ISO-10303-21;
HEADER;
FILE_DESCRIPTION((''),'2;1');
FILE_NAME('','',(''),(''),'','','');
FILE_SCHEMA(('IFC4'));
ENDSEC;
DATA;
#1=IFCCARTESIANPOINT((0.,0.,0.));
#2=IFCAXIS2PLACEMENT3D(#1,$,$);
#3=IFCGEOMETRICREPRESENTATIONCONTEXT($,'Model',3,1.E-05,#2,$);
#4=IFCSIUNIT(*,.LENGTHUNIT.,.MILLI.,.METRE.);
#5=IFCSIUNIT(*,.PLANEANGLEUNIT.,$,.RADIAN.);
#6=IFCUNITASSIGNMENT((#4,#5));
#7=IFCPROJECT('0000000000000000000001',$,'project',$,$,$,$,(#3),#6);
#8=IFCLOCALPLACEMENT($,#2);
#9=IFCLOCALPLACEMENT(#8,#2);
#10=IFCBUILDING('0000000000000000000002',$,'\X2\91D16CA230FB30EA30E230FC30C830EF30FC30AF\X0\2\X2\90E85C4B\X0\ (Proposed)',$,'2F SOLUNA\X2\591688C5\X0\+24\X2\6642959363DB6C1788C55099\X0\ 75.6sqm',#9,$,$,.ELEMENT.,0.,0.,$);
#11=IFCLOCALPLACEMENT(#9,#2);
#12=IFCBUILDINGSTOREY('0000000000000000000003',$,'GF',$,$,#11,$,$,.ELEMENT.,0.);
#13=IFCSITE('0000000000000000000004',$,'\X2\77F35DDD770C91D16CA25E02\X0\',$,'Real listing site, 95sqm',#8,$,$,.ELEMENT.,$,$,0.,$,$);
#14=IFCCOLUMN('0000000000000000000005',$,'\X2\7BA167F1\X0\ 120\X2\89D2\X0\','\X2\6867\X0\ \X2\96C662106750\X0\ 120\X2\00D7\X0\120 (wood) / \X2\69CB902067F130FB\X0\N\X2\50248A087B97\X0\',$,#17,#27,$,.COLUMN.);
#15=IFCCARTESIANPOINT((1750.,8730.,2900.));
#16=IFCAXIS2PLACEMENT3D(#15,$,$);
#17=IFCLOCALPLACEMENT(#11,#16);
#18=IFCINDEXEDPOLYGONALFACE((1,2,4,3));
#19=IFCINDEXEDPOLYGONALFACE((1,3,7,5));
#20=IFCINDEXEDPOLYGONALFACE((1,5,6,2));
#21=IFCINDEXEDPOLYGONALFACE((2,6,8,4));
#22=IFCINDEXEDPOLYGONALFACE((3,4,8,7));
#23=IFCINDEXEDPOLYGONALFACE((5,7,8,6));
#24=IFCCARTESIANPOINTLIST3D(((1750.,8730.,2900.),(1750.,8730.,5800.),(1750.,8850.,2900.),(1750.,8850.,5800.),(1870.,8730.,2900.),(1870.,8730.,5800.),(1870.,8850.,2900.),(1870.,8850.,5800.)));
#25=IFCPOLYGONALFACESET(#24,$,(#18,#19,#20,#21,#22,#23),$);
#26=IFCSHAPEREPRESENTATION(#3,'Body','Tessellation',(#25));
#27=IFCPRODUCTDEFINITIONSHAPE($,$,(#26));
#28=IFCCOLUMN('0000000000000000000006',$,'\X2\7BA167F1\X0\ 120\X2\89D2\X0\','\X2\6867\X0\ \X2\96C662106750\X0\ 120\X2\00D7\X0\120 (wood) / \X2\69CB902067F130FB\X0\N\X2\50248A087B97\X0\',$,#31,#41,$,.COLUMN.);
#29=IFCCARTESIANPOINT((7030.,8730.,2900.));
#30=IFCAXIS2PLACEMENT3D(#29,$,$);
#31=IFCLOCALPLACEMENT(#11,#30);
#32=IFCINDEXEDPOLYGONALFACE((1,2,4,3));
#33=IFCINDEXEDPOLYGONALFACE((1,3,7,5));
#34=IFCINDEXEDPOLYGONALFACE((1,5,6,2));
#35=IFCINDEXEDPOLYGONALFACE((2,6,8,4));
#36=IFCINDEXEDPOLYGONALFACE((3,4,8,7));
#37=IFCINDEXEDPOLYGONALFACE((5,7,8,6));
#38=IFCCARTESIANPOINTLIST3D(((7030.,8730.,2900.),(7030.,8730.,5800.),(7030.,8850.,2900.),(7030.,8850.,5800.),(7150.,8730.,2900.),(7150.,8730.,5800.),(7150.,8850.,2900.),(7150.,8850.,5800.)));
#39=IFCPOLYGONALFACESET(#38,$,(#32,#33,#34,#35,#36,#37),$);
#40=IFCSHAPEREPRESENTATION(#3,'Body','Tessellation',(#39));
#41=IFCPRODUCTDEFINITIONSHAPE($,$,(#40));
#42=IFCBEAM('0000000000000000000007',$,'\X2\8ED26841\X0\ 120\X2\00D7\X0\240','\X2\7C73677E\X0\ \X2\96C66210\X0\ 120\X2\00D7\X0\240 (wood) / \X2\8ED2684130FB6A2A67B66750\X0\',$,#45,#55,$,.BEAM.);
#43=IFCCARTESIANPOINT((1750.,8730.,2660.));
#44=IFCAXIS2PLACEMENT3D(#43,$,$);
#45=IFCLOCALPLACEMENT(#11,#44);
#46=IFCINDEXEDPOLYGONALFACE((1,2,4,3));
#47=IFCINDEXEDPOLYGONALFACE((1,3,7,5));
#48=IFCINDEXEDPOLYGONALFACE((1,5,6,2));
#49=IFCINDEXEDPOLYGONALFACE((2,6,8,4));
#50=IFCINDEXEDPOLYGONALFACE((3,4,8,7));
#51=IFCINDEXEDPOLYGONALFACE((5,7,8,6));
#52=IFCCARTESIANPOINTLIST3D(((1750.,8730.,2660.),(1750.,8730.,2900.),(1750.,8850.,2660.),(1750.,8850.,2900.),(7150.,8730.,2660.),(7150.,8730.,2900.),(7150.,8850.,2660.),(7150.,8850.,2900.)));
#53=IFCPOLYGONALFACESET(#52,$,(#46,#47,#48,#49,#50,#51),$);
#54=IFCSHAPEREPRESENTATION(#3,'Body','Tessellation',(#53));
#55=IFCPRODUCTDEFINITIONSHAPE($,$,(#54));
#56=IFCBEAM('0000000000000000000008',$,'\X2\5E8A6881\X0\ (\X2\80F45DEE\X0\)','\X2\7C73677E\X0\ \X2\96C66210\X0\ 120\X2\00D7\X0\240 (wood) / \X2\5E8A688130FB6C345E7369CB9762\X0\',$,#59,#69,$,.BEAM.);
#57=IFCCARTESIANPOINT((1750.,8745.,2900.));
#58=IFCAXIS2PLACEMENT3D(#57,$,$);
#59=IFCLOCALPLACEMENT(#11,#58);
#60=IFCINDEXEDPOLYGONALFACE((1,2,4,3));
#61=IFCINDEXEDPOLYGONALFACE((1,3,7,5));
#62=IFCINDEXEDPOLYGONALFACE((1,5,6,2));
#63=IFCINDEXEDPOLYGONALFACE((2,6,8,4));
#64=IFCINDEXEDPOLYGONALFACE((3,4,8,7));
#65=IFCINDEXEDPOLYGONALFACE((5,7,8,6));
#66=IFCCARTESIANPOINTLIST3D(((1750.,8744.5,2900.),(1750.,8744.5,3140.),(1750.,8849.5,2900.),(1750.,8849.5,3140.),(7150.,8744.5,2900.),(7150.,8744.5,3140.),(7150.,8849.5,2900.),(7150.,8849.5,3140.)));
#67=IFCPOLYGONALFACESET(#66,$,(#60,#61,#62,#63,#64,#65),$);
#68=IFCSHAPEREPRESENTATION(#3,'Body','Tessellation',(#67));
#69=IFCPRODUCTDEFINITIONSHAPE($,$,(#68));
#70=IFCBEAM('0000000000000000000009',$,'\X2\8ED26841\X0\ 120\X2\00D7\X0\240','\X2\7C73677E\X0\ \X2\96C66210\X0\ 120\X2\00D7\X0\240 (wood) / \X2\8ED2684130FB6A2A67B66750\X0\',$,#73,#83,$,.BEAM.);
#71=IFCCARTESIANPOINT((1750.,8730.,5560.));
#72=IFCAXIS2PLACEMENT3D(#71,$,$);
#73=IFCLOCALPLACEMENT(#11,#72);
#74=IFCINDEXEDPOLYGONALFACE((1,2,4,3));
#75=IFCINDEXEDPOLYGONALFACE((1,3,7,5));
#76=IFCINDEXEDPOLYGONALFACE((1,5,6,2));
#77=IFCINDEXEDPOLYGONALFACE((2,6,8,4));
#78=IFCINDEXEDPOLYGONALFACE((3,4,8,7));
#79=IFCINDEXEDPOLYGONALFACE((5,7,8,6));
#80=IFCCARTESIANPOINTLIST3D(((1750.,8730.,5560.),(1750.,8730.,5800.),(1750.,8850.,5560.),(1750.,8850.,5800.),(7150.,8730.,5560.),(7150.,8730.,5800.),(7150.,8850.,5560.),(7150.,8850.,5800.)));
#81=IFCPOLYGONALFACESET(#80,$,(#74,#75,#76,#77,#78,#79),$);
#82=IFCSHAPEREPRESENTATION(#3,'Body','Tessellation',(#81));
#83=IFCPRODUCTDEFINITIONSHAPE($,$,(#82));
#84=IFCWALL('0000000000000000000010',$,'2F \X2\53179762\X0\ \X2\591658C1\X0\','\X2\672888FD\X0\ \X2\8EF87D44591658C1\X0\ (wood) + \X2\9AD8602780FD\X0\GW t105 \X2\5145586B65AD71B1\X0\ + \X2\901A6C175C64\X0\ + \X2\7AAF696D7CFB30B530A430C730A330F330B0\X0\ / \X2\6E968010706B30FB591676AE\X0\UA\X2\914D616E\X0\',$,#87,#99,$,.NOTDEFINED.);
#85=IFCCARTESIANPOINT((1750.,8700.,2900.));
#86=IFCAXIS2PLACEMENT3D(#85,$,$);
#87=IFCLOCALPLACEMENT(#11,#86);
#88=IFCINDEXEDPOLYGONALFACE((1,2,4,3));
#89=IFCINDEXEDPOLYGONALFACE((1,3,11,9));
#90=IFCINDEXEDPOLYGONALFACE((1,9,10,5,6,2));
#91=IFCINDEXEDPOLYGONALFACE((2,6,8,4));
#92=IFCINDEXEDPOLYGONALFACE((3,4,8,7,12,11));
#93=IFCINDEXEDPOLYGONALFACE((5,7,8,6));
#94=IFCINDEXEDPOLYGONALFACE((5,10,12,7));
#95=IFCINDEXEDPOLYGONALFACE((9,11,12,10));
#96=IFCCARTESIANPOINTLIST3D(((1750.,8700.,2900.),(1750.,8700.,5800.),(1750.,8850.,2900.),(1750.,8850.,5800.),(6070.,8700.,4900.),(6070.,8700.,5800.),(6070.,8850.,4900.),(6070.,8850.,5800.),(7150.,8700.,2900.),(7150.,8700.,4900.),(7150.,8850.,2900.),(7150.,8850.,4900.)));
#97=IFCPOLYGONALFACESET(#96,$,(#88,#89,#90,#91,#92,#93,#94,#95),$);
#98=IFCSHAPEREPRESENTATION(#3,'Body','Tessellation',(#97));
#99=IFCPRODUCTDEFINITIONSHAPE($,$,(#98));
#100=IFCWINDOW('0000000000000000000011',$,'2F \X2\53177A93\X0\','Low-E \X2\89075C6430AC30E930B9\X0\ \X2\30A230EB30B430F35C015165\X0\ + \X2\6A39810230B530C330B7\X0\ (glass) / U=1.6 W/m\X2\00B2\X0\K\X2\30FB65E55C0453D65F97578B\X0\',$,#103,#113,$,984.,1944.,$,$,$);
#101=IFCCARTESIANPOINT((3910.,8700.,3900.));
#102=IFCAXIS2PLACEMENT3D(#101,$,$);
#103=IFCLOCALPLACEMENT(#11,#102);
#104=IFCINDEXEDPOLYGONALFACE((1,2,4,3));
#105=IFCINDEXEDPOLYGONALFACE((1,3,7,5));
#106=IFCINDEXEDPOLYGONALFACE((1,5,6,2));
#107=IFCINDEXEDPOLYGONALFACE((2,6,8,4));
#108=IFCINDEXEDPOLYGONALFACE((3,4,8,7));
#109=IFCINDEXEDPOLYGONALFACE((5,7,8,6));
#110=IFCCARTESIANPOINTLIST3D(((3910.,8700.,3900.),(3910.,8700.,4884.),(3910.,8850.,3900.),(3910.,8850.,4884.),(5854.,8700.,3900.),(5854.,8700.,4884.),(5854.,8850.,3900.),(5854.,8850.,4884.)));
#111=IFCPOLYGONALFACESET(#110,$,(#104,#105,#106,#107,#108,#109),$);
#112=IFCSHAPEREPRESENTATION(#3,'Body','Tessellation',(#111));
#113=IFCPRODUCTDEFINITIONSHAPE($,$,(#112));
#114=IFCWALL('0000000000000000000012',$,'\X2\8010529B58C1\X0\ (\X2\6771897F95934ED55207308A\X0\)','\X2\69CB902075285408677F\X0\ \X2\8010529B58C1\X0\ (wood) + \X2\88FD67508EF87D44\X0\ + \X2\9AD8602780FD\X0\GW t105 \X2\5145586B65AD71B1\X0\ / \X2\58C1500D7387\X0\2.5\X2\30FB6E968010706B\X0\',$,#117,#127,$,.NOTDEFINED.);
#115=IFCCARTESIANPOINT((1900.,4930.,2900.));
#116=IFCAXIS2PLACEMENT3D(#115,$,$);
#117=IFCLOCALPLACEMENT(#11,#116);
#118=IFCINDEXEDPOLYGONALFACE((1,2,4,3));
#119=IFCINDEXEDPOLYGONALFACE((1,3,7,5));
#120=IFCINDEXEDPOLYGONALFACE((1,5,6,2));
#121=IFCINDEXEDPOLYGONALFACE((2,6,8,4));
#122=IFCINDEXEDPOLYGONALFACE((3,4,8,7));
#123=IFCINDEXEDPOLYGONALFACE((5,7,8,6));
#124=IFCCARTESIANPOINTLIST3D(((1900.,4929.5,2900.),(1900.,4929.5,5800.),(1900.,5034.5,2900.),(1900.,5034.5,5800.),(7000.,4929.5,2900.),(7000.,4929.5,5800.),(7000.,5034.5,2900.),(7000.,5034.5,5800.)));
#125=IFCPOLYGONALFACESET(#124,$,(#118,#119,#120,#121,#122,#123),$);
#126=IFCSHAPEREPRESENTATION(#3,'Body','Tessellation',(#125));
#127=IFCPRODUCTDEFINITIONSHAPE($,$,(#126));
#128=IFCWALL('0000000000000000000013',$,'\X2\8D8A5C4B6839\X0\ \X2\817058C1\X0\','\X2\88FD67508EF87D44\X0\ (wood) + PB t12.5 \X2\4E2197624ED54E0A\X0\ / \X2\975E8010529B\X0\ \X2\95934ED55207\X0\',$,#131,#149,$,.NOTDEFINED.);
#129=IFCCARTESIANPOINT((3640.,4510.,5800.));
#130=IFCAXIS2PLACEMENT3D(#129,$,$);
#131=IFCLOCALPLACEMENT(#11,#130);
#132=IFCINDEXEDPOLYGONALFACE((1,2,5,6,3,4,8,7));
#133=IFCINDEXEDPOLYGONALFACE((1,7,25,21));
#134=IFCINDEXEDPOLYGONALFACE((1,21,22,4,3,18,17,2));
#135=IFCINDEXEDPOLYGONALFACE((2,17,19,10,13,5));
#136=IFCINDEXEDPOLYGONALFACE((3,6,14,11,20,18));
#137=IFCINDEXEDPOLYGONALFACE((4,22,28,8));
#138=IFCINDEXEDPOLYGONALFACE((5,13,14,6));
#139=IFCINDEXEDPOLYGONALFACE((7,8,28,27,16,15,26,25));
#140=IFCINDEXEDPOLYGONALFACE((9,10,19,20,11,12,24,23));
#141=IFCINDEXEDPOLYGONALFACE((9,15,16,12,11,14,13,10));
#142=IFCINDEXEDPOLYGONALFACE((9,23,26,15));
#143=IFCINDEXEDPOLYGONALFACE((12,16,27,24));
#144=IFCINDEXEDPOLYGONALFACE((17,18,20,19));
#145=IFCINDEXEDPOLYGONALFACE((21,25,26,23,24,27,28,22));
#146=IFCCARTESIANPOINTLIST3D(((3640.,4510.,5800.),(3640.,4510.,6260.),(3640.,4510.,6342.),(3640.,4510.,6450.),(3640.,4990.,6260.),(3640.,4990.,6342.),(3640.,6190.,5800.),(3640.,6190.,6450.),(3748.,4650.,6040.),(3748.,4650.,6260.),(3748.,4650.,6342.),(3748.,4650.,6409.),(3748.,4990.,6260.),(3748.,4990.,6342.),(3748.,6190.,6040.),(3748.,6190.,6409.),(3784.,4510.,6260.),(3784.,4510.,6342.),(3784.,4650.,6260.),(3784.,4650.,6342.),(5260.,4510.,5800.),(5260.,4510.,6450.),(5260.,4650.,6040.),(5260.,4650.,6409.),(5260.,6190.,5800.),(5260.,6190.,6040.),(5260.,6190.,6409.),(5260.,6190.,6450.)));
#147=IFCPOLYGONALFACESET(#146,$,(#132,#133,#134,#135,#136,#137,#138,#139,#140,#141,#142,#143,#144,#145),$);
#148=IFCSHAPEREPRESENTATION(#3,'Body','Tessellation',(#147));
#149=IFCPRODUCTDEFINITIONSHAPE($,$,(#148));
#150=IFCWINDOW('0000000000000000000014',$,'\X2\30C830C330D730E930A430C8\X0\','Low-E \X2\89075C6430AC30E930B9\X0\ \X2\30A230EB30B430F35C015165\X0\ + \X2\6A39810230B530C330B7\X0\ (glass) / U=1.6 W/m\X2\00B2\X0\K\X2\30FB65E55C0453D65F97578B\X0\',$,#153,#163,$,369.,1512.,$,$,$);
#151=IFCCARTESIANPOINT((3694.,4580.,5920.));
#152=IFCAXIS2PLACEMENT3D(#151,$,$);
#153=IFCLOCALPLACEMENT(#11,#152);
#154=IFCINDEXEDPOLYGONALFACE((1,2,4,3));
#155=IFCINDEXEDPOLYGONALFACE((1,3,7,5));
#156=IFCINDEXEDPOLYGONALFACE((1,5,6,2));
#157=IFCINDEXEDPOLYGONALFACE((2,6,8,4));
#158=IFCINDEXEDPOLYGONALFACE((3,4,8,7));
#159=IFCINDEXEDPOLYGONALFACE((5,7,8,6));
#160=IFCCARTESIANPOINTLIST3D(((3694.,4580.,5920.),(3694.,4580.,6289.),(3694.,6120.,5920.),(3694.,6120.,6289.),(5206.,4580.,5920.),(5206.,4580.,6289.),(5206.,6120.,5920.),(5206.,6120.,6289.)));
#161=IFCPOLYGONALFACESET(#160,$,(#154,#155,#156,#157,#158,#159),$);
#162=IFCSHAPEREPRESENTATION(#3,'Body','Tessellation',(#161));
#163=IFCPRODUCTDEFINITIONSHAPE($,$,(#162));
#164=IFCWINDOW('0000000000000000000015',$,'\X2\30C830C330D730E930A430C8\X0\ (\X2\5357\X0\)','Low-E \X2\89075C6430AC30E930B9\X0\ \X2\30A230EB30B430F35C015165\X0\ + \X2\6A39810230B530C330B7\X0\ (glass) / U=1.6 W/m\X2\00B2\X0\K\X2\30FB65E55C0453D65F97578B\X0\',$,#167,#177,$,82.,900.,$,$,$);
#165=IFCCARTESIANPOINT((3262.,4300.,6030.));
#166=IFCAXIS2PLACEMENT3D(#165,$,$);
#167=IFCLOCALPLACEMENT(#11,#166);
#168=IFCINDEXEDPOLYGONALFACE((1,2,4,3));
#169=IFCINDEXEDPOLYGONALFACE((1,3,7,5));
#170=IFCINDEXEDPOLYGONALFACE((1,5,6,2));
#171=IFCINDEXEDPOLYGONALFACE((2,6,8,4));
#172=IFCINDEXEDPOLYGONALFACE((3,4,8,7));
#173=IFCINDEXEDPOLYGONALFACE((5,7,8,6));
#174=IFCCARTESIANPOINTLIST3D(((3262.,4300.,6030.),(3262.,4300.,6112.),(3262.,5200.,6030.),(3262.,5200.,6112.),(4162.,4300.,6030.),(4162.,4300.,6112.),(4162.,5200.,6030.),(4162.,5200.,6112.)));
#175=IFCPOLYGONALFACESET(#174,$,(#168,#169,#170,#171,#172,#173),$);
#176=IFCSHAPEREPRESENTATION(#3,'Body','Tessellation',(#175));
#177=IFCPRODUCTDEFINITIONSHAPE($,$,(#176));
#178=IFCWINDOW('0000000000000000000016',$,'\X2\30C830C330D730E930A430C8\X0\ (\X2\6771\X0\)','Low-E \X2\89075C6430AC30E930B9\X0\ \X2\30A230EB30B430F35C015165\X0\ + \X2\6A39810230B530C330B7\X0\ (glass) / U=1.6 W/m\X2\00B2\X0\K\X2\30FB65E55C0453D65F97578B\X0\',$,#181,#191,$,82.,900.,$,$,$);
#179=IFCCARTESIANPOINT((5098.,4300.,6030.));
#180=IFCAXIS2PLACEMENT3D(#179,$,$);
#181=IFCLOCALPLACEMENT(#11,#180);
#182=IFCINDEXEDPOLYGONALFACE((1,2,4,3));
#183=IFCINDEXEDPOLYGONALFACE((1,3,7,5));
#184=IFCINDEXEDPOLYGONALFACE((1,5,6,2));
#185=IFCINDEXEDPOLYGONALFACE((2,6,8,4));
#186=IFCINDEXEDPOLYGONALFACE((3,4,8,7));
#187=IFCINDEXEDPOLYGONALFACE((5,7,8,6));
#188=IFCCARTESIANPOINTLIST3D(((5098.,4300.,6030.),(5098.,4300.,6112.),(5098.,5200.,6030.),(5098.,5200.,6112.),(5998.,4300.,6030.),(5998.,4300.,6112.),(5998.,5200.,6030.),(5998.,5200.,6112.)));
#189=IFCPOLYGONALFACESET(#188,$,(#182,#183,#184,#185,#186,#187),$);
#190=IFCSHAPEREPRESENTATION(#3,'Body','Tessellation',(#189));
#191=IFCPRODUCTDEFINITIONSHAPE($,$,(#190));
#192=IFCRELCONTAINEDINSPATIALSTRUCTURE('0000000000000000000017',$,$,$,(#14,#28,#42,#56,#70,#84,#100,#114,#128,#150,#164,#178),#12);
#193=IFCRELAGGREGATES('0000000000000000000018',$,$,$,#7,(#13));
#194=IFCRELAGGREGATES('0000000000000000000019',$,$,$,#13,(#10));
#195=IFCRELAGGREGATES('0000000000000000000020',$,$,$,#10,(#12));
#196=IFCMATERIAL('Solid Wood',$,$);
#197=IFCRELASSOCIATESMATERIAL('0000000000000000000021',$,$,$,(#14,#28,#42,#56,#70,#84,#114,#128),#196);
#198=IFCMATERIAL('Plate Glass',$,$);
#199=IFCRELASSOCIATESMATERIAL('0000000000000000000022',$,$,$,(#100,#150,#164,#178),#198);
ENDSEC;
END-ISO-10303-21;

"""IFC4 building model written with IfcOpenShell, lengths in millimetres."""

from ifc_helpers import new_model, si_unit, frame, frame_2d, origin, place, context, project, spatial, rectangle, extrude, material, element, fill, save


model = new_model("IFC4")

# Units and contexts
model_context = context("Model", 3, precision=1e-05, world=origin())
ifc_project = project(units=[si_unit("LENGTHUNIT", "METRE", prefix="MILLI"), si_unit("PLANEANGLEUNIT", "RADIAN")], contexts=[model_context])

# Site, building, storey
site_placement = place(None, origin())
site = spatial("IfcSite", under=ifc_project, at=site_placement, Name="石川県金沢市", ObjectType="Real listing site, 95sqm", CompositionType="ELEMENT", RefElevation=0.0)
building_placement = place(site_placement, origin())
building = spatial("IfcBuilding", under=site, at=building_placement, Name="金沢・リモートワーク2部屋 (Proposed)", ObjectType="2F SOLUNA外装+24時間換気装備 75.6sqm", CompositionType="ELEMENT", ElevationOfRefHeight=0.0, ElevationOfTerrain=0.0)
storey_placement = place(building_placement, origin())
storey = spatial("IfcBuildingStorey", under=building, at=storey_placement, Name="GF", CompositionType="ELEMENT", Elevation=0.0)

# Columns
ifc_material_1 = material(Name="Solid Wood")
column_1_placement = place(storey_placement, frame((1750.0, 8730.0, 2900.0)))
element("IfcColumn", 1, at=column_1_placement, inside=storey, material=ifc_material_1, Name="管柱 120角", Description="桧 集成材 120×120 (wood) / 構造柱・N値計算", PredefinedType="COLUMN", context=model_context, shape_type="SweptSolid", body=[
    extrude(rectangle(XDim=120.0, YDim=120.0, at=frame_2d((60.0, 60.0))), frame((1750.0, 8730.0, 2900.0)), (0.0, 0.0, 1.0), 2900.0),
])
column_2_placement = place(storey_placement, frame((7030.0, 8730.0, 2900.0)))
element("IfcColumn", 2, at=column_2_placement, inside=storey, material=ifc_material_1, Name="管柱 120角", Description="桧 集成材 120×120 (wood) / 構造柱・N値計算", PredefinedType="COLUMN", context=model_context, shape_type="SweptSolid", body=[
    extrude(rectangle(XDim=120.0, YDim=120.0, at=frame_2d((60.0, 60.0))), frame((7030.0, 8730.0, 2900.0)), (0.0, 0.0, 1.0), 2900.0),
])

# Beams
beam_1_placement = place(storey_placement, frame((1750.0, 8730.0, 2660.0)))
element("IfcBeam", 3, at=beam_1_placement, inside=storey, material=ifc_material_1, Name="軒桁 120×240", Description="米松 集成 120×240 (wood) / 軒桁・横架材", PredefinedType="BEAM", context=model_context, shape_type="SweptSolid", body=[
    extrude(rectangle(XDim=5400.0, YDim=120.0, at=frame_2d((2700.0, 60.0))), frame((1750.0, 8730.0, 2660.0)), (0.0, 0.0, 1.0), 240.0),
])
beam_2_placement = place(storey_placement, frame((1750.0, 8745.0, 2900.0)))
element("IfcBeam", 4, at=beam_2_placement, inside=storey, material=ifc_material_1, Name="床梁 (胴差)", Description="米松 集成 120×240 (wood) / 床梁・水平構面", PredefinedType="BEAM", context=model_context, shape_type="SweptSolid", body=[
    extrude(rectangle(XDim=5400.0, YDim=105.0, at=frame_2d((2700.0, 52.0))), frame((1750.0, 8745.0, 2900.0)), (0.0, 0.0, 1.0), 240.0),
])
beam_3_placement = place(storey_placement, frame((1750.0, 8730.0, 5560.0)))
element("IfcBeam", 5, at=beam_3_placement, inside=storey, material=ifc_material_1, Name="軒桁 120×240", Description="米松 集成 120×240 (wood) / 軒桁・横架材", PredefinedType="BEAM", context=model_context, shape_type="SweptSolid", body=[
    extrude(rectangle(XDim=5400.0, YDim=120.0, at=frame_2d((2700.0, 60.0))), frame((1750.0, 8730.0, 5560.0)), (0.0, 0.0, 1.0), 240.0),
])

# Wall, opening, window
wall_1_placement = place(storey_placement, frame((1750.0, 8700.0, 2900.0)))
wall_1 = element("IfcWall", 6, at=wall_1_placement, inside=storey, material=ifc_material_1, Name="2F 北面 外壁", Description="木製 軸組外壁 (wood) + 高性能GW t105 充填断熱 + 通気層 + 窯業系サイディング / 準耐火・外皮UA配慮", PredefinedType="NOTDEFINED", context=model_context, shape_type="SweptSolid", body=[
    extrude(rectangle(XDim=5400.0, YDim=150.0, at=frame_2d((2700.0, 75.0))), frame((1750.0, 8700.0, 2900.0)), (0.0, 0.0, 1.0), 2900.0),
])
opening_1_placement = place(storey_placement, frame((3910.0, 8700.0, 3900.0)))
opening_1 = element("IfcOpeningElement", 7, at=opening_1_placement, cuts=wall_1, PredefinedType="NOTDEFINED", context=model_context, shape_type="SweptSolid", body=[
    extrude(rectangle(XDim=1944.0, YDim=150.0, at=frame_2d((972.0, 75.0))), frame((3910.0, 8700.0, 3900.0)), (0.0, 0.0, 1.0), 984.0),
])
ifc_material_2 = material(Name="Plate Glass")
window_1_placement = place(storey_placement, frame((3910.0, 8700.0, 3900.0)))
window_1 = element("IfcWindow", 8, at=window_1_placement, inside=storey, material=ifc_material_2, Name="2F 北窓", Description="Low-E 複層ガラス アルゴン封入 + 樹脂サッシ (glass) / U=1.6 W/m²K・日射取得型", OverallHeight=984.0, OverallWidth=1944.0, context=model_context, shape_type="SweptSolid", body=[
    extrude(rectangle(XDim=1944.0, YDim=150.0, at=frame_2d((972.0, 75.0))), frame((3910.0, 8700.0, 3900.0)), (0.0, 0.0, 1.0), 984.0),
])
fill(opening_1, window_1)

# Wall
wall_2_placement = place(storey_placement, frame((1900.0, 4930.0, 2900.0)))
element("IfcWall", 9, at=wall_2_placement, inside=storey, material=ifc_material_1, Name="耐力壁 (東西間仕切り)", Description="構造用合板 耐力壁 (wood) + 製材軸組 + 高性能GW t105 充填断熱 / 壁倍率2.5・準耐火", PredefinedType="NOTDEFINED", context=model_context, shape_type="SweptSolid", body=[
    extrude(rectangle(XDim=5100.0, YDim=105.0, at=frame_2d((2550.0, 52.0))), frame((1900.0, 4930.0, 2900.0)), (0.0, 0.0, 1.0), 2900.0),
])

# Wall, openings, windows
wall_3_placement = place(storey_placement, frame((3640.0, 4510.0, 5800.0)))
wall_3 = element("IfcWall", 10, at=wall_3_placement, inside=storey, material=ifc_material_1, Name="越屋根 腰壁", Description="製材軸組 (wood) + PB t12.5 両面仕上 / 非耐力 間仕切", PredefinedType="NOTDEFINED", context=model_context, shape_type="SweptSolid", body=[
    extrude(rectangle(XDim=1620.0, YDim=1680.0, at=frame_2d((810.0, 840.0))), frame((3640.0, 4510.0, 5800.0)), (0.0, 0.0, 1.0), 650.0),
])
opening_2_placement = place(storey_placement, frame((3694.0, 4580.0, 5920.0)))
opening_2 = element("IfcOpeningElement", 11, at=opening_2_placement, cuts=wall_3, PredefinedType="NOTDEFINED", context=model_context, shape_type="SweptSolid", body=[
    extrude(rectangle(XDim=1512.0, YDim=1540.0, at=frame_2d((756.0, 770.0))), frame((3694.0, 4580.0, 5920.0)), (0.0, 0.0, 1.0), 369.0),
])
opening_3_placement = place(storey_placement, frame((3262.0, 4300.0, 6030.0)))
opening_3 = element("IfcOpeningElement", 12, at=opening_3_placement, cuts=wall_3, PredefinedType="NOTDEFINED", context=model_context, shape_type="SweptSolid", body=[
    extrude(rectangle(XDim=900.0, YDim=900.0, at=frame_2d((450.0, 450.0))), frame((3262.0, 4300.0, 6030.0)), (0.0, 0.0, 1.0), 82.0),
])
opening_4_placement = place(storey_placement, frame((5098.0, 4300.0, 6030.0)))
opening_4 = element("IfcOpeningElement", 13, at=opening_4_placement, cuts=wall_3, PredefinedType="NOTDEFINED", context=model_context, shape_type="SweptSolid", body=[
    extrude(rectangle(XDim=900.0, YDim=900.0, at=frame_2d((450.0, 450.0))), frame((5098.0, 4300.0, 6030.0)), (0.0, 0.0, 1.0), 82.0),
])
window_2_placement = place(storey_placement, frame((3694.0, 4580.0, 5920.0)))
window_2 = element("IfcWindow", 14, at=window_2_placement, inside=storey, material=ifc_material_2, Name="トップライト", Description="Low-E 複層ガラス アルゴン封入 + 樹脂サッシ (glass) / U=1.6 W/m²K・日射取得型", OverallHeight=369.0, OverallWidth=1512.0, context=model_context, shape_type="SweptSolid", body=[
    extrude(rectangle(XDim=1512.0, YDim=1540.0, at=frame_2d((756.0, 770.0))), frame((3694.0, 4580.0, 5920.0)), (0.0, 0.0, 1.0), 369.0),
])
fill(opening_2, window_2)
window_3_placement = place(storey_placement, frame((3262.0, 4300.0, 6030.0)))
window_3 = element("IfcWindow", 15, at=window_3_placement, inside=storey, material=ifc_material_2, Name="トップライト (南)", Description="Low-E 複層ガラス アルゴン封入 + 樹脂サッシ (glass) / U=1.6 W/m²K・日射取得型", OverallHeight=82.0, OverallWidth=900.0, context=model_context, shape_type="SweptSolid", body=[
    extrude(rectangle(XDim=900.0, YDim=900.0, at=frame_2d((450.0, 450.0))), frame((3262.0, 4300.0, 6030.0)), (0.0, 0.0, 1.0), 82.0),
])
fill(opening_3, window_3)
window_4_placement = place(storey_placement, frame((5098.0, 4300.0, 6030.0)))
window_4 = element("IfcWindow", 16, at=window_4_placement, inside=storey, material=ifc_material_2, Name="トップライト (東)", Description="Low-E 複層ガラス アルゴン封入 + 樹脂サッシ (glass) / U=1.6 W/m²K・日射取得型", OverallHeight=82.0, OverallWidth=900.0, context=model_context, shape_type="SweptSolid", body=[
    extrude(rectangle(XDim=900.0, YDim=900.0, at=frame_2d((450.0, 450.0))), frame((5098.0, 4300.0, 6030.0)), (0.0, 0.0, 1.0), 82.0),
])
fill(opening_4, window_4)

save(model, "model.ifc")
